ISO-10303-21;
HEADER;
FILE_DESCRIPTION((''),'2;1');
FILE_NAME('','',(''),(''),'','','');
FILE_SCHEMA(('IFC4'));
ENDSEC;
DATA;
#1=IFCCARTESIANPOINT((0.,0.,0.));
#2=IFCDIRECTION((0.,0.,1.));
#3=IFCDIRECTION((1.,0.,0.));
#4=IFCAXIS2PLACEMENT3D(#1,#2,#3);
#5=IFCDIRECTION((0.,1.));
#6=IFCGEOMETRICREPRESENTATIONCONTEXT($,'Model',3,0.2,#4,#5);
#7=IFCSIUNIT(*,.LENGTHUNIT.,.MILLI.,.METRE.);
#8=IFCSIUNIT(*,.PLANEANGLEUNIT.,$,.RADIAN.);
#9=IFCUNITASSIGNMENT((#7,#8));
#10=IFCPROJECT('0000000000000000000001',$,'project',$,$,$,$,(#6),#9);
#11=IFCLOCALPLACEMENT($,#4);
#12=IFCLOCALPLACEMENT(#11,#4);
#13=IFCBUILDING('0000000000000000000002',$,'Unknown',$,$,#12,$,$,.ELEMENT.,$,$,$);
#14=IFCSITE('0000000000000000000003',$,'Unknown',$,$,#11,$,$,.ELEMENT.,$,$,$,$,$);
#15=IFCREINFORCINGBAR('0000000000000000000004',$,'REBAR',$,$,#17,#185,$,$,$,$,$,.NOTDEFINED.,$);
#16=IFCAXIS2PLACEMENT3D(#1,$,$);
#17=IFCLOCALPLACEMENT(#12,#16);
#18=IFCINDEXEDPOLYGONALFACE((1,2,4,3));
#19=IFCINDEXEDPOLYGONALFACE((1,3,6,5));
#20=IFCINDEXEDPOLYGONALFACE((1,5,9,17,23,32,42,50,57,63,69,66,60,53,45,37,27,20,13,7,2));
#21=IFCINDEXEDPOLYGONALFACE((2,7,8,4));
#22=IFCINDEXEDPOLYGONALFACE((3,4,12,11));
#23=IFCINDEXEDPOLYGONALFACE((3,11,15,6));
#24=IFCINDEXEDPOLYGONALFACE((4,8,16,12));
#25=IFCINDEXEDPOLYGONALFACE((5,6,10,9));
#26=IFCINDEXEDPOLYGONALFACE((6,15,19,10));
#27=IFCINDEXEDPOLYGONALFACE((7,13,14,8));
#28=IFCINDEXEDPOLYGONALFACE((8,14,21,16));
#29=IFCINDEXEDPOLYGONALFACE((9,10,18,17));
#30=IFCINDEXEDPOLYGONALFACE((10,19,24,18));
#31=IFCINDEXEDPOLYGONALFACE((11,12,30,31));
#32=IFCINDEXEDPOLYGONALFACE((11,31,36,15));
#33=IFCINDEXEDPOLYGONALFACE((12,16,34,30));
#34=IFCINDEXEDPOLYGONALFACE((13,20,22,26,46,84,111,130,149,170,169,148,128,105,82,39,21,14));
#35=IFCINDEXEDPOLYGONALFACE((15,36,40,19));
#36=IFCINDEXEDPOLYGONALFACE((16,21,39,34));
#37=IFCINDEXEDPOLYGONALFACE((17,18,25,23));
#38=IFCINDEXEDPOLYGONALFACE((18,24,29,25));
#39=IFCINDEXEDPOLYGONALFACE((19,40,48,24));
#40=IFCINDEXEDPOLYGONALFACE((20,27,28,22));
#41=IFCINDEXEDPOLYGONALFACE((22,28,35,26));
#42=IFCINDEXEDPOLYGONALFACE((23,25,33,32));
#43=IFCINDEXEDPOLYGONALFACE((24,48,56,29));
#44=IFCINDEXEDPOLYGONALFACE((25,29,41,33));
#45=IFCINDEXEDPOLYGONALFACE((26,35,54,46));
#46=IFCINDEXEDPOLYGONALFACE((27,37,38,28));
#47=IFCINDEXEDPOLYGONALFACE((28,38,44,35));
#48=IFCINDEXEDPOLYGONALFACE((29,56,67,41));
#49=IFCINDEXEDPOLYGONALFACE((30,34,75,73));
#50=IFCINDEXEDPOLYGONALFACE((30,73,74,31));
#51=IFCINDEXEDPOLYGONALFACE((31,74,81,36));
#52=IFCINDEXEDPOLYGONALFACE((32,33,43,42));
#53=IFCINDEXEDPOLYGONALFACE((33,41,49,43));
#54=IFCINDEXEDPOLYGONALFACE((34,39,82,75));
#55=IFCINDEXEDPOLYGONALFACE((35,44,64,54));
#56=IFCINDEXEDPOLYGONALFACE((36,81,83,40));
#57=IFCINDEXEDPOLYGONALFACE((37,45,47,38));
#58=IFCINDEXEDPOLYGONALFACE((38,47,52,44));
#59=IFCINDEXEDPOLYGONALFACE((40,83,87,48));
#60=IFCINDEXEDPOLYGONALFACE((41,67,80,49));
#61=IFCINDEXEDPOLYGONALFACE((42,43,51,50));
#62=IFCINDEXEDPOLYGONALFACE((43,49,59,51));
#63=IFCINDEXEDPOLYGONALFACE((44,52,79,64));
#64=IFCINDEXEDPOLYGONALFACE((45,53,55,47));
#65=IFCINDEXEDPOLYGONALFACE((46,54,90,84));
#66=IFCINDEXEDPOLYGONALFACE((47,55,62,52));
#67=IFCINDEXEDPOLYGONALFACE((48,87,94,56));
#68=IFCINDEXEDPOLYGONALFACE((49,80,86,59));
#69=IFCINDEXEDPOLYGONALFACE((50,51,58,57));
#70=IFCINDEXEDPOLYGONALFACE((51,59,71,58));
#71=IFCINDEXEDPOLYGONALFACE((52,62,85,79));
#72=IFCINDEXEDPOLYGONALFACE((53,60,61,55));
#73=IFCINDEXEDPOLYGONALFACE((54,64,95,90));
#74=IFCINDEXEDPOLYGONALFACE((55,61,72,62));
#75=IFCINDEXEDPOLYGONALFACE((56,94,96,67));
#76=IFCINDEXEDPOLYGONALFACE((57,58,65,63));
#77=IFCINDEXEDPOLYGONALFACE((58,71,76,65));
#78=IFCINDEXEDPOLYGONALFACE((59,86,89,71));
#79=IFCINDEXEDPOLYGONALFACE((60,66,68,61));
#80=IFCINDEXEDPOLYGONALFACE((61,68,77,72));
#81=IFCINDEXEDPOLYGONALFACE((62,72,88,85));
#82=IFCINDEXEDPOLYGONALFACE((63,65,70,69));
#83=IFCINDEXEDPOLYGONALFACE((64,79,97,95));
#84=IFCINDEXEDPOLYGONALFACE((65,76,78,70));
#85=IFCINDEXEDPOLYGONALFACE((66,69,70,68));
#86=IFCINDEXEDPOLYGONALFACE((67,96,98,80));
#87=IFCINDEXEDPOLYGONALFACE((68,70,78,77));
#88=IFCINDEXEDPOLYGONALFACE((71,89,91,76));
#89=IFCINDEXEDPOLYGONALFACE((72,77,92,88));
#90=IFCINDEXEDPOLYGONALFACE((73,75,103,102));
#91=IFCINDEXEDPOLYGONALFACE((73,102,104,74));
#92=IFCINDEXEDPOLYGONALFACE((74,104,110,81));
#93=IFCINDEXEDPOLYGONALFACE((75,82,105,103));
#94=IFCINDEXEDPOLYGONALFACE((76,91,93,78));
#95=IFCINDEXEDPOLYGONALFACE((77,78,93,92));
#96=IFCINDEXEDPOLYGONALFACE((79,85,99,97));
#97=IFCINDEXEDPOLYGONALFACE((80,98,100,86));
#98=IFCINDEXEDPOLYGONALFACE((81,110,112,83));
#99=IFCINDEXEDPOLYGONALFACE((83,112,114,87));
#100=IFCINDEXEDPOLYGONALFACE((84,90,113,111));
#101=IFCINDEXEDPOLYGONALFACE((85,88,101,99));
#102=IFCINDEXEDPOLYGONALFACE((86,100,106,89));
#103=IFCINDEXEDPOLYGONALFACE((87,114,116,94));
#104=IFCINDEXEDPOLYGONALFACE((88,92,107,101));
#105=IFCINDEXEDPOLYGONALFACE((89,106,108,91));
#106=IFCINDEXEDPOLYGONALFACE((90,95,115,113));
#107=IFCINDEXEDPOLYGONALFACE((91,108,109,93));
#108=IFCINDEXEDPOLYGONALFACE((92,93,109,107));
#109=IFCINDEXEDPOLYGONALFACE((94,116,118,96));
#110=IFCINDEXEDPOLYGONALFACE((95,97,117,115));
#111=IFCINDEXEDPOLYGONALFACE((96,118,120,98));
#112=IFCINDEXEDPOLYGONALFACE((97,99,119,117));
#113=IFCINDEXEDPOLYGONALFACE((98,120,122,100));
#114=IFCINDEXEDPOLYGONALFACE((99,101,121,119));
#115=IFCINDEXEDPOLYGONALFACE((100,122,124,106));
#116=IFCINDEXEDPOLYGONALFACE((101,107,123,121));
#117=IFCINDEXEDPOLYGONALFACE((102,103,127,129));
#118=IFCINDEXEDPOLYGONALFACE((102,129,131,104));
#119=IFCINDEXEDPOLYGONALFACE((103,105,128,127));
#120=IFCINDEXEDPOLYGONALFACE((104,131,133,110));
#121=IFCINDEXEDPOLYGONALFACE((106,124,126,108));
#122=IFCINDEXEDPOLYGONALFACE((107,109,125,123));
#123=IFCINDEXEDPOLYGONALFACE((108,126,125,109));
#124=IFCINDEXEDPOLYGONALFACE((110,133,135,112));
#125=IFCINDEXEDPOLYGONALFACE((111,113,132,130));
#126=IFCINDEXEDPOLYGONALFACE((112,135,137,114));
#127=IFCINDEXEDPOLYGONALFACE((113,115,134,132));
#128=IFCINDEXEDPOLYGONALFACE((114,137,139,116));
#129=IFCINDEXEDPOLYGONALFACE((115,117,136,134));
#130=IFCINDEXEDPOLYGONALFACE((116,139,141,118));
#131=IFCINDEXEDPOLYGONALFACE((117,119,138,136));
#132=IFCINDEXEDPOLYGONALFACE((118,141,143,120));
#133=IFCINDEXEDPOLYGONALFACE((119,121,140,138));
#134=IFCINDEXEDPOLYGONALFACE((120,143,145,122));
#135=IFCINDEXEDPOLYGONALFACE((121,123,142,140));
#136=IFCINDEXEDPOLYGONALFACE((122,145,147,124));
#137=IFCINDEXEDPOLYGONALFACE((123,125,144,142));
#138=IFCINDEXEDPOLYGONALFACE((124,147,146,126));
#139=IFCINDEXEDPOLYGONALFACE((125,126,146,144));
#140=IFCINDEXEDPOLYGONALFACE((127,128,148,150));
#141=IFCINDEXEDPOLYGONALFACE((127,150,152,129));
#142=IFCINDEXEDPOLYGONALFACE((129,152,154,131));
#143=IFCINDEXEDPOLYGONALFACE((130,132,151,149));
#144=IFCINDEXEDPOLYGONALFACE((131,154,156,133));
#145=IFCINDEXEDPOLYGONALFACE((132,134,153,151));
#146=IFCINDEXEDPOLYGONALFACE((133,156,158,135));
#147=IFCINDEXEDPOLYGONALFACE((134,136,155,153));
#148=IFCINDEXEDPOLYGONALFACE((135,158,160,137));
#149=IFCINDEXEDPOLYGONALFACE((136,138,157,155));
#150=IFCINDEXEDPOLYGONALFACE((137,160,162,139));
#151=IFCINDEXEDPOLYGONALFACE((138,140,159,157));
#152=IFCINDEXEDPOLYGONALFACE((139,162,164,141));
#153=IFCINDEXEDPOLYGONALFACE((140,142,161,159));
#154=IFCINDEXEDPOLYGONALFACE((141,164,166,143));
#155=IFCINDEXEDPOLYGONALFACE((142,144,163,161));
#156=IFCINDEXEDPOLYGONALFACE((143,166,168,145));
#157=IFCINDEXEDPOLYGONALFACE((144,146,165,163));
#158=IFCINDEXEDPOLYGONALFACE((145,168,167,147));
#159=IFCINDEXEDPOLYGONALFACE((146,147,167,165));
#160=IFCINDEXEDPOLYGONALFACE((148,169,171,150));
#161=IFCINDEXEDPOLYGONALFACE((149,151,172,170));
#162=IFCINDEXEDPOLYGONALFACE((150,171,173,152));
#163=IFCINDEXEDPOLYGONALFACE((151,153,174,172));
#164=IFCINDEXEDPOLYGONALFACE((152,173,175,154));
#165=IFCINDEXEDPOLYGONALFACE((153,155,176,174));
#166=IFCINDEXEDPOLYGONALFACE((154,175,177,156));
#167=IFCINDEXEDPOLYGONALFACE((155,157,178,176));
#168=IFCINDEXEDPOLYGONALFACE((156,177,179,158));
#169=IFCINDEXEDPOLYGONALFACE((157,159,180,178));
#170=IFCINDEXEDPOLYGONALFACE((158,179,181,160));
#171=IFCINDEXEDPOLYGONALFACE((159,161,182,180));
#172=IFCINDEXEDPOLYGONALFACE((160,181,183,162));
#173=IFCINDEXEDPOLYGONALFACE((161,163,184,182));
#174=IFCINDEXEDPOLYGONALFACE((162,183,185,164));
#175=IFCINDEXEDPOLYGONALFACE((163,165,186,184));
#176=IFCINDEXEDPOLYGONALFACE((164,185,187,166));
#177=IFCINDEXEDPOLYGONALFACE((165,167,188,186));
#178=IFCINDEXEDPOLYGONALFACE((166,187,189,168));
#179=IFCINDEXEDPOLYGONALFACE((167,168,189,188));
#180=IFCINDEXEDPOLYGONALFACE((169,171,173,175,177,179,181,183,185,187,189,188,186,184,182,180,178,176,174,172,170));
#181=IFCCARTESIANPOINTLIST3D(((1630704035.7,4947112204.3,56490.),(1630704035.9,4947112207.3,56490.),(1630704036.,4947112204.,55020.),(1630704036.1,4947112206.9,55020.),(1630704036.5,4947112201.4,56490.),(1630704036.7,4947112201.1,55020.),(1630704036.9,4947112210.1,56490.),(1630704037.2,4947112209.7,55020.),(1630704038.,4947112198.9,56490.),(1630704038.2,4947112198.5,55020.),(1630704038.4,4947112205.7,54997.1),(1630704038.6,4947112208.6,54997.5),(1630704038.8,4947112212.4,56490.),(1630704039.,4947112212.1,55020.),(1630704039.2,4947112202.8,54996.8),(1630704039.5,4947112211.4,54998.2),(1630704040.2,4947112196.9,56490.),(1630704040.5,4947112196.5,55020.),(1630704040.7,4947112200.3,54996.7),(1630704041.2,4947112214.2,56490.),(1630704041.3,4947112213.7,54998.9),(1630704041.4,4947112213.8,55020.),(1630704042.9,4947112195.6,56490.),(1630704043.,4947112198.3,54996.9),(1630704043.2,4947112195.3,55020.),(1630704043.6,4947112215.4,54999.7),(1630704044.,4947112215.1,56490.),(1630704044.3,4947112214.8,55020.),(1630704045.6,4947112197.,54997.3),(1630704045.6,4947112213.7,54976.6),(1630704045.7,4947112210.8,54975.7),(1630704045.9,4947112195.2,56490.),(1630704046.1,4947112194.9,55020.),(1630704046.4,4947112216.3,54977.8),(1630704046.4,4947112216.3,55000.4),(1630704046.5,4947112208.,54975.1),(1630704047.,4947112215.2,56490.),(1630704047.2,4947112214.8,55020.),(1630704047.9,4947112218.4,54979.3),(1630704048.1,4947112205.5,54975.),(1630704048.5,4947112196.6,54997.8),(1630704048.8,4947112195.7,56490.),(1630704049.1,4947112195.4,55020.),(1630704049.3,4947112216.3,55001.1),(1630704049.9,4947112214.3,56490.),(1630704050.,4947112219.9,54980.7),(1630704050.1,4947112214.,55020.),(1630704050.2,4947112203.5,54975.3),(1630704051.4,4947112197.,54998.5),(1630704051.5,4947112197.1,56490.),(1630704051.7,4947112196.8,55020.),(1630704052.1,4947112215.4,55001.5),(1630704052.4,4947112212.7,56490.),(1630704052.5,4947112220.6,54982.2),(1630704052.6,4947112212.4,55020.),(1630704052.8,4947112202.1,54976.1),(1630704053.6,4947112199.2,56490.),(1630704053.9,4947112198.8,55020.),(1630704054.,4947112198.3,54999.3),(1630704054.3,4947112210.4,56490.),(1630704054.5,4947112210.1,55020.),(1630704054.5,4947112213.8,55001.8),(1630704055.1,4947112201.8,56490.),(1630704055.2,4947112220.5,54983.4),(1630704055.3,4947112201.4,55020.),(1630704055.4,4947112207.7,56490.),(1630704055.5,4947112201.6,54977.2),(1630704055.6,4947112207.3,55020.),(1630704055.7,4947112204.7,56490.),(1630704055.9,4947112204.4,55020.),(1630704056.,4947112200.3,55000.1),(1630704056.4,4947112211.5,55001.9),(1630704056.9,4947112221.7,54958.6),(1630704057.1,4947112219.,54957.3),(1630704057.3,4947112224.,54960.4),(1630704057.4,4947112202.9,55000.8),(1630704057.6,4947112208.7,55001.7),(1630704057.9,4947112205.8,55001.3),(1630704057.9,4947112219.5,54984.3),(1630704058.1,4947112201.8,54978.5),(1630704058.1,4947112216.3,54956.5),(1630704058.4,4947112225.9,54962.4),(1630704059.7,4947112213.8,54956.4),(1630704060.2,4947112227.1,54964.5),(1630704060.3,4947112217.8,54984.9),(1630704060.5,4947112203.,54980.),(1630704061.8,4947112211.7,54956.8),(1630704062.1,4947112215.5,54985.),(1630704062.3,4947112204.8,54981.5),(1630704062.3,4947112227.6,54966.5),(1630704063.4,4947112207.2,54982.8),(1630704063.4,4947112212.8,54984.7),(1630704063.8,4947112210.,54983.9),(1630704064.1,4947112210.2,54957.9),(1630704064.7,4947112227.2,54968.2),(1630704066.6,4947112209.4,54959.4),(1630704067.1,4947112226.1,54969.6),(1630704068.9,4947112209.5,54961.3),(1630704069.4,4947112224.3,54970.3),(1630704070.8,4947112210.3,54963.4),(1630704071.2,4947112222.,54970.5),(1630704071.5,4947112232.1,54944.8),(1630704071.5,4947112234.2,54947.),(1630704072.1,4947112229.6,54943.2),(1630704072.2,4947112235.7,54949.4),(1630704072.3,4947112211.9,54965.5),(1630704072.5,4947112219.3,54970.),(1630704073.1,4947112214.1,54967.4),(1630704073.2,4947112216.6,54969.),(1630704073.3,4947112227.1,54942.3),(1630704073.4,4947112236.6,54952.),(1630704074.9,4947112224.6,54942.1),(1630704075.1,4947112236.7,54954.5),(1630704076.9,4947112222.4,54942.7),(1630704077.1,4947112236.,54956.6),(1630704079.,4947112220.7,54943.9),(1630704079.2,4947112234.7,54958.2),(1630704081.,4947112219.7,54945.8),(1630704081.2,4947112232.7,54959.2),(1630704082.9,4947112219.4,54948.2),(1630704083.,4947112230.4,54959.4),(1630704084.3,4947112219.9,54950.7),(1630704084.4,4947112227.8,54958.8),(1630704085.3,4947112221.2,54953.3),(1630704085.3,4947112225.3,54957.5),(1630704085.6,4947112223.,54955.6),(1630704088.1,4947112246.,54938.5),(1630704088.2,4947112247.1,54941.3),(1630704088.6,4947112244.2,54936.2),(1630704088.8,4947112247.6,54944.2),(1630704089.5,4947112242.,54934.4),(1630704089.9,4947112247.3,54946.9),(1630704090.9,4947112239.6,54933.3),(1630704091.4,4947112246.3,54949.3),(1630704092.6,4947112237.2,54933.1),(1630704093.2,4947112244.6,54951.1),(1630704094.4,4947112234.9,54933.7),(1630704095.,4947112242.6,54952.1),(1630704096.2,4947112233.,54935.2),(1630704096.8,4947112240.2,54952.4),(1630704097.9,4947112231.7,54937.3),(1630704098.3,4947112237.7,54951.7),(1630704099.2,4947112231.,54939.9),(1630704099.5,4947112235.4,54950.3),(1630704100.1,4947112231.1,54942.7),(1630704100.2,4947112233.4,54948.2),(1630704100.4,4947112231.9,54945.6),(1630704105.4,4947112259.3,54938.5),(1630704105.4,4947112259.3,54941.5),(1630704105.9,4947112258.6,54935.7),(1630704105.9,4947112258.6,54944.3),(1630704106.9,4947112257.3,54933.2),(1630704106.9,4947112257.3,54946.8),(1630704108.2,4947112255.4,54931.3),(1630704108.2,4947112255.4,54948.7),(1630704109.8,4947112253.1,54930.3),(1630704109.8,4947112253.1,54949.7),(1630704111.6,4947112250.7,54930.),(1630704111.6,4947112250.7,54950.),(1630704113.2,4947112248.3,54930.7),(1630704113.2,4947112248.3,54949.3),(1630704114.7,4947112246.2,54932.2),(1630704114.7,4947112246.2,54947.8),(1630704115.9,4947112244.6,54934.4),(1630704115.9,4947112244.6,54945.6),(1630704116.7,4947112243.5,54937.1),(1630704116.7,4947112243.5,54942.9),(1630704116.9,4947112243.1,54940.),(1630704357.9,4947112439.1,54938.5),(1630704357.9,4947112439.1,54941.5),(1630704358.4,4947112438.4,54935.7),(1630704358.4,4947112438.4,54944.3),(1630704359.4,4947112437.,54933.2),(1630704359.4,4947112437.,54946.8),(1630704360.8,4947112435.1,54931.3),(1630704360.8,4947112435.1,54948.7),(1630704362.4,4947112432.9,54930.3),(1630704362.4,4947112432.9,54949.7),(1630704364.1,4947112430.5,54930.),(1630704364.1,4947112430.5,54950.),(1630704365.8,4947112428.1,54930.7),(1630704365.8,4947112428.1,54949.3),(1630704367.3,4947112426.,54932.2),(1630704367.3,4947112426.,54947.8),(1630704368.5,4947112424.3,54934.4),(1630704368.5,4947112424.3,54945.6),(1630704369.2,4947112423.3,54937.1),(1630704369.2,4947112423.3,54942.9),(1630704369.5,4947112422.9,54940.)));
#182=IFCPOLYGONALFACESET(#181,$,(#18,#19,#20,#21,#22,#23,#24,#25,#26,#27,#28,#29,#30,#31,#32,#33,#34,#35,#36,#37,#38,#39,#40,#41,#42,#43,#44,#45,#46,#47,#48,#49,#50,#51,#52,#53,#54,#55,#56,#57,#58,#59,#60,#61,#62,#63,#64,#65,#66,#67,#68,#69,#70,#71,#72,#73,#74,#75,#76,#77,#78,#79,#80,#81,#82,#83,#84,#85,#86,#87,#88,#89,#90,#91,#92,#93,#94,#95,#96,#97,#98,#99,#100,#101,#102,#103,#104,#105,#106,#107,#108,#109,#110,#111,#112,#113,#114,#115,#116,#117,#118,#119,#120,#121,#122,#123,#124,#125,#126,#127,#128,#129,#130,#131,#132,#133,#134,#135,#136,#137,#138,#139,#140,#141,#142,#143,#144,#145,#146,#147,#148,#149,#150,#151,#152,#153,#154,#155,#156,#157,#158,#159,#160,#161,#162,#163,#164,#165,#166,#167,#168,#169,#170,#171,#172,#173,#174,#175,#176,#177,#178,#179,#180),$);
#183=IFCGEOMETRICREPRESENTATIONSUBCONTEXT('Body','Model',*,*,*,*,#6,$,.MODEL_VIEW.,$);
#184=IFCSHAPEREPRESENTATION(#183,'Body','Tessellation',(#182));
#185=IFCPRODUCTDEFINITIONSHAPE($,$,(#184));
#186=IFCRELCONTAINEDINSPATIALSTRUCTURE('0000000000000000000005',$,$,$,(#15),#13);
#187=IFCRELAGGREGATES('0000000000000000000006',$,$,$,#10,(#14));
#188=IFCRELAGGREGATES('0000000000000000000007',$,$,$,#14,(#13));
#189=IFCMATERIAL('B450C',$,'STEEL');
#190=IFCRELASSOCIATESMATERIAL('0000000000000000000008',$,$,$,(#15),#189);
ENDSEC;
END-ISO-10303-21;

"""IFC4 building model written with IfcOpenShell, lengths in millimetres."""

from ifc_helpers import new_model, entity, si_unit, direction, frame, origin_with_axes, place, context, subcontext, project, spatial, material, element, save


model = new_model("IFC4")

# Units and contexts
model_context = context("Model", 3, precision=0.2, world=origin_with_axes(), true_north=direction((0.0, 1.0)))
body_context = subcontext(model_context, "Body", "Model", "MODEL_VIEW")
ifc_project = project(units=[si_unit("LENGTHUNIT", "METRE", prefix="MILLI"), si_unit("PLANEANGLEUNIT", "RADIAN")], contexts=[model_context])

# Site, building
site_placement = place(None, origin_with_axes())
site = spatial("IfcSite", under=ifc_project, at=site_placement, Name="Unknown", CompositionType="ELEMENT")
building_placement = place(site_placement, origin_with_axes())
building = spatial("IfcBuilding", under=site, at=building_placement, Name="Unknown", CompositionType="ELEMENT")

# Reinforcing bar
ifc_material = material(Name="B450C", Category="STEEL")
reinforcing_bar_1_placement = place(building_placement, frame((1630703976.2, 4947112216.6, 54890.0), z_axis=(0.580234, -0.81445, 0.0), x_axis=(0.0, 0.0, 1.0)))
element("IfcReinforcingBar", 1, at=reinforcing_bar_1_placement, inside=building, material=ifc_material, Name="REBAR", PredefinedType="NOTDEFINED", context=body_context, shape_type="AdvancedSweptSolid", body=[
    entity("IfcSweptDiskSolid", entity("IfcIndexedPolyCurve", entity("IfcCartesianPointList3D", [[50.0, -440.0, 50.1], [50.0, -130.0, 50.0], [73.4, -73.4, 50.0], [130.0, -50.0, 50.0], [1600.0, -50.0, 49.6]]), [entity("IfcLineIndex", [1, 2]), entity("IfcArcIndex", [2, 3, 4]), entity("IfcLineIndex", [4, 5])]), 10.0),
])

save(model, "model.ifc")
